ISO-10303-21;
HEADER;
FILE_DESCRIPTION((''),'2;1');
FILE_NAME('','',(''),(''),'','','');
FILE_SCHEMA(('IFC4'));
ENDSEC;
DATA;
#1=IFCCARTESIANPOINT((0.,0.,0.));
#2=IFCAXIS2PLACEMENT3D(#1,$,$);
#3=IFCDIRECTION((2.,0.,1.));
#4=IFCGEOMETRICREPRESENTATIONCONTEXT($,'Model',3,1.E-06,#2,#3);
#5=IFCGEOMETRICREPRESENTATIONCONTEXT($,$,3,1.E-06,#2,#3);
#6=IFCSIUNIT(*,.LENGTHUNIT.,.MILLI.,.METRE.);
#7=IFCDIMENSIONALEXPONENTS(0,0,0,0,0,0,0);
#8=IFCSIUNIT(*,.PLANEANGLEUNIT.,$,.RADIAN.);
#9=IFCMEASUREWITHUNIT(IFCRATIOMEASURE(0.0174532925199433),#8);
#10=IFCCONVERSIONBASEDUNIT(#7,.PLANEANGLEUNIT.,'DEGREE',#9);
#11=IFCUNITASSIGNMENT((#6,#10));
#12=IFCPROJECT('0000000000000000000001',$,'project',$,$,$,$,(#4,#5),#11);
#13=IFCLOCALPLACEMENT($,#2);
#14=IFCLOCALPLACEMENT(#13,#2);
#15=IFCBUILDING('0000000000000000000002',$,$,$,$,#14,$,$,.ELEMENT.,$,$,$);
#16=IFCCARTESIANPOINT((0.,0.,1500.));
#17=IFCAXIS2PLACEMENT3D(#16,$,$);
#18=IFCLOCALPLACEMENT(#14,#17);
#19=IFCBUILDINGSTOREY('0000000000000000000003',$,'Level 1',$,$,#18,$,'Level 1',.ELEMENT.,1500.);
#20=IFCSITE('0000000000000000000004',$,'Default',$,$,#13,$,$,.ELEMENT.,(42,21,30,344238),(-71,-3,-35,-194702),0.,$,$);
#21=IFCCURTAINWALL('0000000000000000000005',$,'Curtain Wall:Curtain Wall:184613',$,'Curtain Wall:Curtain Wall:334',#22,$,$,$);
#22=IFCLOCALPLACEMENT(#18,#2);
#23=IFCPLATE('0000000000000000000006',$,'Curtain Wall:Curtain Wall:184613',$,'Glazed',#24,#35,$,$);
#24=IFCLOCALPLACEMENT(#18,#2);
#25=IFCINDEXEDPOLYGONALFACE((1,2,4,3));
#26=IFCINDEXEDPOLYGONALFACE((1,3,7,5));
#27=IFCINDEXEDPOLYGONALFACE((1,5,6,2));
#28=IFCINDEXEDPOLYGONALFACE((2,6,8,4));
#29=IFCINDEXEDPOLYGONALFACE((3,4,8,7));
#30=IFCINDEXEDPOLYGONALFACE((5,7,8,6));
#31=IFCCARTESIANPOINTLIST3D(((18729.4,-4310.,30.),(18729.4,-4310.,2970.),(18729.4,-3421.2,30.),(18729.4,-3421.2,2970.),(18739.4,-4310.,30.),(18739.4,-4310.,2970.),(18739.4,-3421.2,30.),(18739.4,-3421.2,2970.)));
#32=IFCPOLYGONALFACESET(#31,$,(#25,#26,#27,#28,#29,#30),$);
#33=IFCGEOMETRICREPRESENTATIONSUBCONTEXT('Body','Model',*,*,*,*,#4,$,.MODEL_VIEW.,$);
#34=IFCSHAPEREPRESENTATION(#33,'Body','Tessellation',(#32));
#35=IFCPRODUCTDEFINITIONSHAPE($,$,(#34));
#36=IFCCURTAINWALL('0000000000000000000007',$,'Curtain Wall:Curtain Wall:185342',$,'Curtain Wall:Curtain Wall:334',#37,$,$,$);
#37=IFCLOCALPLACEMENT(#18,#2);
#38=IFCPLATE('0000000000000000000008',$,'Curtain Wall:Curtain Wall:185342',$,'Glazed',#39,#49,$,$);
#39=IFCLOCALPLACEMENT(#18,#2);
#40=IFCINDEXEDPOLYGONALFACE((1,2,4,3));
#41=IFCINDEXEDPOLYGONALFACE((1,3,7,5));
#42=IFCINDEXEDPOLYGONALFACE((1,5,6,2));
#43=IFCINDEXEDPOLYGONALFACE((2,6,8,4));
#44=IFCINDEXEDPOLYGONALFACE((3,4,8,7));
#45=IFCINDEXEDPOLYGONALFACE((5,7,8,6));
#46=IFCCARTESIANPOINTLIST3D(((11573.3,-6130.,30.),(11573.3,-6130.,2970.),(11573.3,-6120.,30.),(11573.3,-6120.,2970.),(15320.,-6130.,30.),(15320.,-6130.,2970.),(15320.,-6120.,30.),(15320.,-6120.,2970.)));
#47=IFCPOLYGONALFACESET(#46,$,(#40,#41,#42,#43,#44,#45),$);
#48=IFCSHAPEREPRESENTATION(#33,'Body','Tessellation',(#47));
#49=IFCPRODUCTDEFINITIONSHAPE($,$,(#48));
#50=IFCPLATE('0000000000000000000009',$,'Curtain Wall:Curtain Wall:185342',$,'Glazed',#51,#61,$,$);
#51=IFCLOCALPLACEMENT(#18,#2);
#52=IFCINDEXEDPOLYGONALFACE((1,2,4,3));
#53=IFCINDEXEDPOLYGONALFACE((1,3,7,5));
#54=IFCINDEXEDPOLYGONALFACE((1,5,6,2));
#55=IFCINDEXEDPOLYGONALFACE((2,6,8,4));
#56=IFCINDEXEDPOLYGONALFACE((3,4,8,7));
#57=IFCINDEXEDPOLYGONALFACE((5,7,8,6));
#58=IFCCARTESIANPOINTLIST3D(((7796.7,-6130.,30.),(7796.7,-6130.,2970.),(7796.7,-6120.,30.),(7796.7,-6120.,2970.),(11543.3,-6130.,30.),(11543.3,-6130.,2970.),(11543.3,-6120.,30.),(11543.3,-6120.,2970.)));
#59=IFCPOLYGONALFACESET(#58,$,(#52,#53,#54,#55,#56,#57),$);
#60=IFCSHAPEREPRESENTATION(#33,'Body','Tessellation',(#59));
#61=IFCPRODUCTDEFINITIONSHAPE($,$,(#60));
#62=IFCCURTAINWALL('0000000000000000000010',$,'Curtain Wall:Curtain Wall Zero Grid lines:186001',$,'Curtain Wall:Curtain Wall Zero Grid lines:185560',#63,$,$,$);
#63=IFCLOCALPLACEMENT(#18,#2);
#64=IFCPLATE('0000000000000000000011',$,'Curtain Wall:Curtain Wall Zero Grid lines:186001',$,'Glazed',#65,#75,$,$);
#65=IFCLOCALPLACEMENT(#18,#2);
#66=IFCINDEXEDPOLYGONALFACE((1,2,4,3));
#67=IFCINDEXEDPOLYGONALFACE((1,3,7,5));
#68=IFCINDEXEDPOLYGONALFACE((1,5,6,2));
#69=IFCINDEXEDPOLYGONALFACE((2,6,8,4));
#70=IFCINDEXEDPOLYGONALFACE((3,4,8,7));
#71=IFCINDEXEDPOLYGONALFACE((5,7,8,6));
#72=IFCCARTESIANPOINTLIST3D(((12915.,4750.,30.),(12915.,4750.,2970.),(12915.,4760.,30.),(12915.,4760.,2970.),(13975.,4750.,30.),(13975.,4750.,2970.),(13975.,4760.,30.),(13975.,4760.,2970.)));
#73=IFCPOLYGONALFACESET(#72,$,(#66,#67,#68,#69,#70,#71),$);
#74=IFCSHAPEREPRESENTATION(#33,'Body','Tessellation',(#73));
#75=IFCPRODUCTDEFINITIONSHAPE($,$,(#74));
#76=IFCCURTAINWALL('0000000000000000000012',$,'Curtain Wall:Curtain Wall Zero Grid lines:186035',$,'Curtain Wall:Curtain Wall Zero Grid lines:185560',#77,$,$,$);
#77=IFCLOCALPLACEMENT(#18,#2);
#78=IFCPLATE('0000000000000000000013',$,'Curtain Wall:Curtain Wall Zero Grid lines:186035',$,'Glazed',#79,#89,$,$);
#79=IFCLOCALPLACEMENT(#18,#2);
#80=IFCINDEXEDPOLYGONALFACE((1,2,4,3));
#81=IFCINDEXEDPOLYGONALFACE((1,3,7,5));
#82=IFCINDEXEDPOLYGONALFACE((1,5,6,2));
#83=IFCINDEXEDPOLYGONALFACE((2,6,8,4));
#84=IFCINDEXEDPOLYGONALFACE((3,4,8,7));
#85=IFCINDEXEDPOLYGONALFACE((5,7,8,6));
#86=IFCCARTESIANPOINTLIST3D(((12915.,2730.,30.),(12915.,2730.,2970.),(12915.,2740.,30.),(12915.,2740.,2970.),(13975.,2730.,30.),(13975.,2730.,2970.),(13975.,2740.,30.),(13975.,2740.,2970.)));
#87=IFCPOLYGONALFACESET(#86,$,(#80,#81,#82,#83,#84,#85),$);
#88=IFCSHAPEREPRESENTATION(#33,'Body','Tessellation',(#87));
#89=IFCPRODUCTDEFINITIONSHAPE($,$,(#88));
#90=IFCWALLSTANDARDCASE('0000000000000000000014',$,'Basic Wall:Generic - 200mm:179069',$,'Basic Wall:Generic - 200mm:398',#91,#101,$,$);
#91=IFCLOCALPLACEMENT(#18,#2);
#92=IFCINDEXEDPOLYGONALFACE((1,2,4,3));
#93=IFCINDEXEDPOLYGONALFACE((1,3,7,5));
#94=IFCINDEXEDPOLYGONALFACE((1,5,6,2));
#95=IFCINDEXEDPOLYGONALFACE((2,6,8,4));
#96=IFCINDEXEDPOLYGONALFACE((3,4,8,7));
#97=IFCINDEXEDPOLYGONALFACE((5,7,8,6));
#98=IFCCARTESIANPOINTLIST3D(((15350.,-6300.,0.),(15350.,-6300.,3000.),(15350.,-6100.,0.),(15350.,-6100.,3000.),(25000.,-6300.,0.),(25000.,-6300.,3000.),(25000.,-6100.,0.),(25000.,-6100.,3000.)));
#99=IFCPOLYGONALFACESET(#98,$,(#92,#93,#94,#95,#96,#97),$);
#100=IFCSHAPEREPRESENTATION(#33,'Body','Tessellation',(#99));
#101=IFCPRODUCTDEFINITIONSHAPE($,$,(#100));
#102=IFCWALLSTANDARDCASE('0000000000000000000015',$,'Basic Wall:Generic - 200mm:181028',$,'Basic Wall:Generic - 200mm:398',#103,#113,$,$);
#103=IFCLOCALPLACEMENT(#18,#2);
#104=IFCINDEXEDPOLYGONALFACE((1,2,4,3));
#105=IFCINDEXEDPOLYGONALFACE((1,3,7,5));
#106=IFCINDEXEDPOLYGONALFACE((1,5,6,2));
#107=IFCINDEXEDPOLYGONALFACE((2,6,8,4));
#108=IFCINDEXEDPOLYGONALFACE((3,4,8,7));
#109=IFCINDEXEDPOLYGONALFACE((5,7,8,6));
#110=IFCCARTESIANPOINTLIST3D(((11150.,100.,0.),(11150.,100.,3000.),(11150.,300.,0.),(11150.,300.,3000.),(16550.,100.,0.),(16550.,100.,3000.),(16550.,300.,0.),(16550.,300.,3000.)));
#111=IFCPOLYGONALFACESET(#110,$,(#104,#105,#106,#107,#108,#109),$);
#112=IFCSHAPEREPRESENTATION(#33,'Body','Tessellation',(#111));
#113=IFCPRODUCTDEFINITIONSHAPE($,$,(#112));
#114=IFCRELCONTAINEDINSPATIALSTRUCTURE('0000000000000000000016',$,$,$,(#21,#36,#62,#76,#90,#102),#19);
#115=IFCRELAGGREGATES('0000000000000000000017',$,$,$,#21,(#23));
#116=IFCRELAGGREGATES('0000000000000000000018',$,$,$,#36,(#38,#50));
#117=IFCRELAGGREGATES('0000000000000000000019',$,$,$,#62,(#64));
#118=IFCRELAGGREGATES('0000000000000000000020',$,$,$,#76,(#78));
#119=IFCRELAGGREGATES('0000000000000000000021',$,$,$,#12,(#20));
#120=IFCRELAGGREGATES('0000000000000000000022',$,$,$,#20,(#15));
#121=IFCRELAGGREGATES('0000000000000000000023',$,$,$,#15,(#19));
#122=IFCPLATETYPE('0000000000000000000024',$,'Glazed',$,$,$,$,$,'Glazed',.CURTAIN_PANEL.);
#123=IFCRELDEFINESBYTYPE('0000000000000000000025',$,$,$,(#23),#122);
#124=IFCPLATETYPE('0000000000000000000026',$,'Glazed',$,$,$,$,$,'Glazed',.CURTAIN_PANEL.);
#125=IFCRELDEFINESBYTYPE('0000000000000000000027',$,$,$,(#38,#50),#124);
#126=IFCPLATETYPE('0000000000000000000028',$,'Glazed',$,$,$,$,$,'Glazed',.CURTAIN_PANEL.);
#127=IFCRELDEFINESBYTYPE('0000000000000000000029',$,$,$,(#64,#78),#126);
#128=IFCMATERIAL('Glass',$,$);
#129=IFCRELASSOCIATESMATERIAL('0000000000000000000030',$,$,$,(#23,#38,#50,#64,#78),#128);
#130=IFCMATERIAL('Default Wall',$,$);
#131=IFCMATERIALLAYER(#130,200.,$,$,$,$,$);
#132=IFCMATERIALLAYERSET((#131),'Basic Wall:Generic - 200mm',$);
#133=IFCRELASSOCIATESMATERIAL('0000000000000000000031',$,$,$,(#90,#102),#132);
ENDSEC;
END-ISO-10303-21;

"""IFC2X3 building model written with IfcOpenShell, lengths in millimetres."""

from ifc_helpers import new_model, entity, si_unit, converted_unit, direction, frame, frame_2d, origin, origin_2d_with_axis, place, context, subcontext, project, spatial, rectangle, extrude, source, transform, mapped, material, layer, layer_set, layer_usage, type_object, type_shapes, element, aggregate, save


model = new_model("IFC2X3")

# Units and contexts
model_context = context("Model", 3, precision=1e-06, world=origin(), true_north=direction((2.0, 0.0, 1.0)))
context_of_model = context(None, 3, precision=1e-06, world=origin(), true_north=direction((2.0, 0.0, 1.0)))
body_context = subcontext(model_context, "Body", "Model", "MODEL_VIEW")
ifc_project = project(units=[si_unit("LENGTHUNIT", "METRE", prefix="MILLI"), converted_unit("PLANEANGLEUNIT", "DEGREE", entity("IfcRatioMeasure", 0.0174532925199433), si_unit("PLANEANGLEUNIT", "RADIAN"), dimensions=[0, 0, 0, 0, 0, 0, 0])], contexts=[model_context, context_of_model])

# Site, building, storey
site_placement = place(None, origin())
site = spatial("IfcSite", under=ifc_project, at=site_placement, Name="Default", CompositionType="ELEMENT", RefLatitude=(42, 21, 30, 344238), RefLongitude=(-71, -3, -35, -194702), RefElevation=0.0)
building_placement = place(site_placement, origin())
building = spatial("IfcBuilding", under=site, at=building_placement, CompositionType="ELEMENT")
storey_placement = place(building_placement, frame((0.0, 0.0, 1500.0)))
storey = spatial("IfcBuildingStorey", under=building, at=storey_placement, Name="Level 1", LongName="Level 1", CompositionType="ELEMENT", Elevation=1500.0)

# Curtain walls, plates
ifc_material_1 = material(Name="Glass")
curtain_wall_1_placement = place(storey_placement, origin())
curtain_wall_1 = element("IfcCurtainWall", 1, at=curtain_wall_1_placement, inside=storey, Name="Curtain Wall:Curtain Wall:184613", ObjectType="Curtain Wall:Curtain Wall:334")
plate_type_1 = type_object("IfcPlateType", Name="Glazed", ElementType="Glazed", PredefinedType="CURTAIN_PANEL")
shared_shape_1 = source(origin(), body_context, "Body", "SweptSolid", [
    extrude(rectangle(XDim=10.0, YDim=888.8, at=origin_2d_with_axis()), frame((0.0, 0.0, 0.0), z_axis=(0.0, 0.0, 1.0), x_axis=(0.0, 1.0, 0.0)), (0.0, 0.0, 1.0), 2940.0),
])
type_shapes(plate_type_1, [shared_shape_1])
plate_1_placement = place(storey_placement, frame((18734.4, -3865.6, 30.0), z_axis=(0.0, 0.0, 1.0), x_axis=(0.0, -1.0, 0.0)))
plate_1 = element("IfcPlate", 2, at=plate_1_placement, type_object=plate_type_1, material=ifc_material_1, Name="Curtain Wall:Curtain Wall:184613", ObjectType="Glazed", context=body_context, shape_type="MappedRepresentation", body=[
    mapped(shared_shape_1, transform((0.0, 0.0, 0.0), scale=1.0)),
])
aggregate(curtain_wall_1, [plate_1])
curtain_wall_2_placement = place(storey_placement, origin())
curtain_wall_2 = element("IfcCurtainWall", 3, at=curtain_wall_2_placement, inside=storey, Name="Curtain Wall:Curtain Wall:185342", ObjectType="Curtain Wall:Curtain Wall:334")
plate_type_2 = type_object("IfcPlateType", Name="Glazed", ElementType="Glazed", PredefinedType="CURTAIN_PANEL")
shared_shape_2 = source(origin(), body_context, "Body", "SweptSolid", [
    extrude(rectangle(XDim=10.0, YDim=3746.7, at=origin_2d_with_axis()), frame((0.0, 0.0, 0.0), z_axis=(0.0, 0.0, 1.0), x_axis=(0.0, 1.0, 0.0)), (0.0, 0.0, 1.0), 2940.0),
])
type_shapes(plate_type_2, [shared_shape_2])
plate_2_placement = place(storey_placement, frame((13446.7, -6125.0, 30.0), z_axis=(0.0, 0.0, 1.0), x_axis=(-1.0, 0.0, 0.0)))
plate_2 = element("IfcPlate", 4, at=plate_2_placement, type_object=plate_type_2, material=ifc_material_1, Name="Curtain Wall:Curtain Wall:185342", ObjectType="Glazed", context=body_context, shape_type="MappedRepresentation", body=[
    mapped(shared_shape_2, transform((0.0, 0.0, 0.0), scale=1.0)),
])
plate_3_placement = place(storey_placement, frame((9670.0, -6125.0, 30.0), z_axis=(0.0, 0.0, 1.0), x_axis=(-1.0, 0.0, 0.0)))
plate_3 = element("IfcPlate", 5, at=plate_3_placement, type_object=plate_type_2, material=ifc_material_1, Name="Curtain Wall:Curtain Wall:185342", ObjectType="Glazed", context=body_context, shape_type="MappedRepresentation", body=[
    mapped(shared_shape_2, transform((0.0, 0.0, 0.0), scale=1.0)),
])
aggregate(curtain_wall_2, [plate_2, plate_3])

# Curtain walls, plates
curtain_wall_3_placement = place(storey_placement, origin())
curtain_wall_3 = element("IfcCurtainWall", 6, at=curtain_wall_3_placement, inside=storey, Name="Curtain Wall:Curtain Wall Zero Grid lines:186001", ObjectType="Curtain Wall:Curtain Wall Zero Grid lines:185560")
plate_type_3 = type_object("IfcPlateType", Name="Glazed", ElementType="Glazed", PredefinedType="CURTAIN_PANEL")
shared_shape_3 = source(origin(), body_context, "Body", "SweptSolid", [
    extrude(rectangle(XDim=10.0, YDim=1060.0, at=origin_2d_with_axis()), frame((0.0, 0.0, 0.0), z_axis=(0.0, 0.0, 1.0), x_axis=(0.0, 1.0, 0.0)), (0.0, 0.0, 1.0), 2940.0),
])
type_shapes(plate_type_3, [shared_shape_3])
plate_4_placement = place(storey_placement, frame((13445.0, 4755.0, 30.0)))
plate_4 = element("IfcPlate", 7, at=plate_4_placement, type_object=plate_type_3, material=ifc_material_1, Name="Curtain Wall:Curtain Wall Zero Grid lines:186001", ObjectType="Glazed", context=body_context, shape_type="MappedRepresentation", body=[
    mapped(shared_shape_3, transform((0.0, 0.0, 0.0), scale=1.0)),
])
aggregate(curtain_wall_3, [plate_4])
curtain_wall_4_placement = place(storey_placement, origin())
curtain_wall_4 = element("IfcCurtainWall", 8, at=curtain_wall_4_placement, inside=storey, Name="Curtain Wall:Curtain Wall Zero Grid lines:186035", ObjectType="Curtain Wall:Curtain Wall Zero Grid lines:185560")
plate_5_placement = place(storey_placement, frame((13445.0, 2735.0, 30.0)))
plate_5 = element("IfcPlate", 9, at=plate_5_placement, type_object=plate_type_3, material=ifc_material_1, Name="Curtain Wall:Curtain Wall Zero Grid lines:186035", ObjectType="Glazed", context=body_context, shape_type="MappedRepresentation", body=[
    mapped(shared_shape_3, transform((0.0, 0.0, 0.0), scale=1.0)),
])
aggregate(curtain_wall_4, [plate_5])

# Walls
ifc_material_2 = material(Name="Default Wall")
ifc_layer = layer(ifc_material_2, 200.0)
ifc_layer_set = layer_set([ifc_layer], Name="Basic Wall:Generic - 200mm")
ifc_layer_usage_1 = layer_usage(ifc_layer_set, "AXIS2", "NEGATIVE", 100.0)
wall_1_placement = place(storey_placement, frame((25000.0, -6200.0, 0.0), z_axis=(0.0, 0.0, 1.0), x_axis=(-1.0, 0.0, 0.0)))
element("IfcWallStandardCase", 10, at=wall_1_placement, inside=storey, material=ifc_layer_usage_1, Name="Basic Wall:Generic - 200mm:179069", ObjectType="Basic Wall:Generic - 200mm:398", context=body_context, shape_type="SweptSolid", body=[
    extrude(rectangle(XDim=9650.0, YDim=200.0, at=frame_2d((4825.0, 0.0), x_axis=(-1.0, 0.0))), origin(), (0.0, 0.0, 1.0), 3000.0),
])
ifc_layer_usage_2 = layer_usage(ifc_layer_set, "AXIS2", "NEGATIVE", 100.0)
wall_2_placement = place(storey_placement, frame((11150.0, 200.0, 0.0)))
element("IfcWallStandardCase", 11, at=wall_2_placement, inside=storey, material=ifc_layer_usage_2, Name="Basic Wall:Generic - 200mm:181028", ObjectType="Basic Wall:Generic - 200mm:398", context=body_context, shape_type="SweptSolid", body=[
    extrude(rectangle(XDim=5400.0, YDim=200.0, at=frame_2d((2700.0, 0.0), x_axis=(-1.0, 0.0))), origin(), (0.0, 0.0, 1.0), 3000.0),
])

save(model, "model.ifc")
